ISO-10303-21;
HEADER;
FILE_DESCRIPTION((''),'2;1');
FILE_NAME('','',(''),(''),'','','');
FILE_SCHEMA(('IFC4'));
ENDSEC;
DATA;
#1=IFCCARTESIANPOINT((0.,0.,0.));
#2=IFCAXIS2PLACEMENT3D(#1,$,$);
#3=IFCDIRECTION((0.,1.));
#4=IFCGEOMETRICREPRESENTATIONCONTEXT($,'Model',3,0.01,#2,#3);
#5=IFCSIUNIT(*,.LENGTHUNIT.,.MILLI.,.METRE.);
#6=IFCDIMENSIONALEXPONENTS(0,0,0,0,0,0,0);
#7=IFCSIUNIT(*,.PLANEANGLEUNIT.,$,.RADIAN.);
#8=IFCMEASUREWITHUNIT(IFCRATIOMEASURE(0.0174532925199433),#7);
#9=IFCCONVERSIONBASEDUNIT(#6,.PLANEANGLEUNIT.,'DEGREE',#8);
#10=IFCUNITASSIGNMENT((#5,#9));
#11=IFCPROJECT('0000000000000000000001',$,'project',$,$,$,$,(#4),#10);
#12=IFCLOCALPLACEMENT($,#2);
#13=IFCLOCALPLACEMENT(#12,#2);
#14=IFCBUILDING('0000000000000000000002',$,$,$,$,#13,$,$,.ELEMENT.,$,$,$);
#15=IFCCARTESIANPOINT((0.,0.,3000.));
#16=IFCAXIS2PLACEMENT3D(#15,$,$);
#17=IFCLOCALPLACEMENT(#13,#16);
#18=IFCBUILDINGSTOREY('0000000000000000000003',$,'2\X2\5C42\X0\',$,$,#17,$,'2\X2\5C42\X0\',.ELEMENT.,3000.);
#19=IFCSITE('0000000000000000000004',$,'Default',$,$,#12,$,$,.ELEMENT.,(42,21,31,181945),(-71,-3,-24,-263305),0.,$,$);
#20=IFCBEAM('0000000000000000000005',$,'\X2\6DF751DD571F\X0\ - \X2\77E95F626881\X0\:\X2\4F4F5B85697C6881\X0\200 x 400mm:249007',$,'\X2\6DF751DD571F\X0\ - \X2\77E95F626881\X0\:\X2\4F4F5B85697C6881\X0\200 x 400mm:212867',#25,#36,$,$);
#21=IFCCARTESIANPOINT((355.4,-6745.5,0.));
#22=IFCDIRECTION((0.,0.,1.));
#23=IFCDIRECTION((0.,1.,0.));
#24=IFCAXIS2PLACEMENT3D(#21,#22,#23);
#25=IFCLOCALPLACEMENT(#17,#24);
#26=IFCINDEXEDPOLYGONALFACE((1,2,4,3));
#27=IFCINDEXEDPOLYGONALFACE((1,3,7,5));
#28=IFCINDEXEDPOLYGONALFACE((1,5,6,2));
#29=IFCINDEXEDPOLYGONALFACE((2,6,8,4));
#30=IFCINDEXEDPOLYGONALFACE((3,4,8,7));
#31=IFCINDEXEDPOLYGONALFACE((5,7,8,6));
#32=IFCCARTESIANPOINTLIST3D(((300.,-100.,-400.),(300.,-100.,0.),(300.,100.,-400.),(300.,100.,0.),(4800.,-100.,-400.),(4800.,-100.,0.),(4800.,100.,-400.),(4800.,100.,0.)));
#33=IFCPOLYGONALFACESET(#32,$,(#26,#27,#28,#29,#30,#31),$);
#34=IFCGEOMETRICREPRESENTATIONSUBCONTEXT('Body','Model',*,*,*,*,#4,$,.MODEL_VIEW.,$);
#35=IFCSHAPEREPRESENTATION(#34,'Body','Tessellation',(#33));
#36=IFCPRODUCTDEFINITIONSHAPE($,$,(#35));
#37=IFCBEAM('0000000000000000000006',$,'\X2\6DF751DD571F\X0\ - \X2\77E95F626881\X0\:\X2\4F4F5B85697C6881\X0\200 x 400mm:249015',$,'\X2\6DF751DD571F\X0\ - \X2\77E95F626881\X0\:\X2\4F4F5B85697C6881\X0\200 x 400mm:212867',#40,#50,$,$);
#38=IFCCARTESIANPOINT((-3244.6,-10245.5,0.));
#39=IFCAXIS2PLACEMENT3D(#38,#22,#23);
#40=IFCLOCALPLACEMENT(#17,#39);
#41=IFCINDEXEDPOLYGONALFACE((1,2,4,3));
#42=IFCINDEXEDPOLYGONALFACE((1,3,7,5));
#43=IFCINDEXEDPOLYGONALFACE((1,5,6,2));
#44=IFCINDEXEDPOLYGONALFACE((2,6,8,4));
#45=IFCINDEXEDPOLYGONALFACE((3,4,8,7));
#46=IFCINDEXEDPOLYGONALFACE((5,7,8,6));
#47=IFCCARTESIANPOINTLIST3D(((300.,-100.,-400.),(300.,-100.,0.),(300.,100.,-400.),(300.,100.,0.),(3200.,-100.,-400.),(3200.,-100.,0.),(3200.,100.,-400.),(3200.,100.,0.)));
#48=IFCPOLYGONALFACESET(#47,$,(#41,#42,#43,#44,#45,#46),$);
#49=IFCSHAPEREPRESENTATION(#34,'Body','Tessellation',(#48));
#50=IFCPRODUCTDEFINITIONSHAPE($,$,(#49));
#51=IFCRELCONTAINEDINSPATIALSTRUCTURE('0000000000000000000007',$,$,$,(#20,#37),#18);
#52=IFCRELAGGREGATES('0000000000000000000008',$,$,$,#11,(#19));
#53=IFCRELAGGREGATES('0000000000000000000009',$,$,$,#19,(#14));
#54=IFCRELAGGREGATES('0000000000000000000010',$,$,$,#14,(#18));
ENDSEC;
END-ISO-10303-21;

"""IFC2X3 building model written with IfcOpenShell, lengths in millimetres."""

from ifc_helpers import new_model, entity, si_unit, converted_unit, direction, frame, frame_2d, origin, origin_2d_with_axis, place, context, subcontext, project, spatial, rectangle, extrude, element, save


model = new_model("IFC2X3")

# Units and contexts
model_context = context("Model", 3, precision=0.01, world=origin(), true_north=direction((0.0, 1.0)))
body_context = subcontext(model_context, "Body", "Model", "MODEL_VIEW")
ifc_project = project(units=[si_unit("LENGTHUNIT", "METRE", prefix="MILLI"), converted_unit("PLANEANGLEUNIT", "DEGREE", entity("IfcRatioMeasure", 0.0174532925199433), si_unit("PLANEANGLEUNIT", "RADIAN"), dimensions=[0, 0, 0, 0, 0, 0, 0])], contexts=[model_context])

# Site, building, storey
site_placement = place(None, origin())
site = spatial("IfcSite", under=ifc_project, at=site_placement, Name="Default", CompositionType="ELEMENT", RefLatitude=(42, 21, 31, 181945), RefLongitude=(-71, -3, -24, -263305), RefElevation=0.0)
building_placement = place(site_placement, origin())
building = spatial("IfcBuilding", under=site, at=building_placement, CompositionType="ELEMENT")
storey_placement = place(building_placement, frame((0.0, 0.0, 3000.0)))
storey = spatial("IfcBuildingStorey", under=building, at=storey_placement, Name="2层", LongName="2层", CompositionType="ELEMENT", Elevation=3000.0)

# Beams
beam_1_placement = place(storey_placement, frame((355.4, -6745.5, 0.0), z_axis=(0.0, 0.0, 1.0), x_axis=(0.0, 1.0, 0.0)))
element("IfcBeam", 1, at=beam_1_placement, inside=storey, Name="混凝土 - 矩形梁:住宅楼梁200 x 400mm:249007", ObjectType="混凝土 - 矩形梁:住宅楼梁200 x 400mm:212867", context=body_context, shape_type="SweptSolid", body=[
    extrude(rectangle(XDim=400.0, YDim=200.0, at=frame_2d((0.0, 0.0), x_axis=(1.0, 0.0))), frame((300.0, 0.0, -200.0), z_axis=(1.0, 0.0, 0.0), x_axis=(0.0, 0.0, -1.0)), (0.0, 0.0, 1.0), 4500.0),
])
beam_2_placement = place(storey_placement, frame((-3244.6, -10245.5, 0.0), z_axis=(0.0, 0.0, 1.0), x_axis=(0.0, 1.0, 0.0)))
element("IfcBeam", 2, at=beam_2_placement, inside=storey, Name="混凝土 - 矩形梁:住宅楼梁200 x 400mm:249015", ObjectType="混凝土 - 矩形梁:住宅楼梁200 x 400mm:212867", context=body_context, shape_type="SweptSolid", body=[
    extrude(rectangle(XDim=400.0, YDim=200.0, at=origin_2d_with_axis()), frame((300.0, 0.0, -200.0), z_axis=(1.0, 0.0, 0.0), x_axis=(0.0, 0.0, -1.0)), (0.0, 0.0, 1.0), 2900.0),
])

save(model, "model.ifc")
